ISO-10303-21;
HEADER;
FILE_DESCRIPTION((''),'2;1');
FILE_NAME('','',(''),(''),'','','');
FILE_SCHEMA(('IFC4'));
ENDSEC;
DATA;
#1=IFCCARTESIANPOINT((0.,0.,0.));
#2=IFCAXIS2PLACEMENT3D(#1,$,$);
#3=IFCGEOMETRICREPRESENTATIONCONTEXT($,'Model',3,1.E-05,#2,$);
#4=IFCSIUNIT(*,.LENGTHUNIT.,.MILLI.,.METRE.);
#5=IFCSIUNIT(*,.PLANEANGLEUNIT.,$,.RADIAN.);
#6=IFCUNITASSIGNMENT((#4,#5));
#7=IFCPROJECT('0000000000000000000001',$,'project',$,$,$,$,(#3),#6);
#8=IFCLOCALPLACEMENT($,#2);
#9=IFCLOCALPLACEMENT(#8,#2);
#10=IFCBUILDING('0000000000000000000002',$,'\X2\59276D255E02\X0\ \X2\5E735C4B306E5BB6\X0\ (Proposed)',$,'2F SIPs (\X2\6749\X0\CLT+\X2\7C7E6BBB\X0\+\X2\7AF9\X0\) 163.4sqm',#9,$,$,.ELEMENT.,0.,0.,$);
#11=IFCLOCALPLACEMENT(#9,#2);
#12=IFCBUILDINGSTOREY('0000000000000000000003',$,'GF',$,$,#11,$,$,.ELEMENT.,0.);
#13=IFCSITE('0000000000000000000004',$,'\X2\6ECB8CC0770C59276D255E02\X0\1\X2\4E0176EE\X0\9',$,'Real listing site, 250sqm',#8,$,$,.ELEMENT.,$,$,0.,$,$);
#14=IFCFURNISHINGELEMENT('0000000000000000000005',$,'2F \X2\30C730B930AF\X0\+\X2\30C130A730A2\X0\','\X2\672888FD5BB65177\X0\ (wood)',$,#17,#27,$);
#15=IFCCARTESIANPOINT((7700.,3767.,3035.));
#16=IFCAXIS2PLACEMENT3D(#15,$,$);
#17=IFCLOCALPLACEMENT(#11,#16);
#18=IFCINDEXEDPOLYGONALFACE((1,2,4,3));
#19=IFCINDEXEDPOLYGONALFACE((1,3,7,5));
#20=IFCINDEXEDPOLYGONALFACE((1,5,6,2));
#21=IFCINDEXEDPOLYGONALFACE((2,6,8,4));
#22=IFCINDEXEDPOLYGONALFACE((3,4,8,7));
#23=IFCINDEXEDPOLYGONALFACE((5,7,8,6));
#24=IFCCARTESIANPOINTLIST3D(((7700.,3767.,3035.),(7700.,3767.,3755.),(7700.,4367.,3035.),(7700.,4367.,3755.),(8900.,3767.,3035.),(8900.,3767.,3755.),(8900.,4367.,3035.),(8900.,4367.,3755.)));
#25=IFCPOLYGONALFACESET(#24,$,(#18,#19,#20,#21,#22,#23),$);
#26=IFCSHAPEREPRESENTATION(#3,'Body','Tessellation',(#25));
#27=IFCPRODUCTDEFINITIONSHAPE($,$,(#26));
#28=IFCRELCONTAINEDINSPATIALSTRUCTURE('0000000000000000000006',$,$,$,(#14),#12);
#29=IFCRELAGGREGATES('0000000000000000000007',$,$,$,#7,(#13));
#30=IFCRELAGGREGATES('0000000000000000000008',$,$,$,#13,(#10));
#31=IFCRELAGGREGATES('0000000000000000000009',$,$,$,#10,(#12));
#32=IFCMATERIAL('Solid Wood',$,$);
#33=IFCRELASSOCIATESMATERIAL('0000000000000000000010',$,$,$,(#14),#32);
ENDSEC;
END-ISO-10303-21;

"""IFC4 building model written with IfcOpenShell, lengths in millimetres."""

from ifc_helpers import new_model, si_unit, frame, frame_2d, origin, place, context, project, spatial, rectangle, extrude, material, element, save


model = new_model("IFC4")

# Units and contexts
model_context = context("Model", 3, precision=1e-05, world=origin())
ifc_project = project(units=[si_unit("LENGTHUNIT", "METRE", prefix="MILLI"), si_unit("PLANEANGLEUNIT", "RADIAN")], contexts=[model_context])

# Site, building, storey
site_placement = place(None, origin())
site = spatial("IfcSite", under=ifc_project, at=site_placement, Name="滋賀県大津市1丁目9", ObjectType="Real listing site, 250sqm", CompositionType="ELEMENT", RefElevation=0.0)
building_placement = place(site_placement, origin())
building = spatial("IfcBuilding", under=site, at=building_placement, Name="大津市 平屋の家 (Proposed)", ObjectType="2F SIPs (杉CLT+籾殻+竹) 163.4sqm", CompositionType="ELEMENT", ElevationOfRefHeight=0.0, ElevationOfTerrain=0.0)
storey_placement = place(building_placement, origin())
storey = spatial("IfcBuildingStorey", under=building, at=storey_placement, Name="GF", CompositionType="ELEMENT", Elevation=0.0)

# Shared definitions
ifc_material_1 = material(Name="Solid Wood")

# Furnishing element
furnishing_1_placement = place(storey_placement, frame((7700.0, 3767.0, 3035.0)))
element("IfcFurnishingElement", 1, at=furnishing_1_placement, inside=storey, material=ifc_material_1, Name="2F デスク+チェア", Description="木製家具 (wood)", context=model_context, shape_type="SweptSolid", body=[
    extrude(rectangle(XDim=1200.0, YDim=600.0, at=frame_2d((600.0, 300.0))), frame((7700.0, 3767.0, 3035.0)), (0.0, 0.0, 1.0), 720.0),
])

save(model, "model.ifc")
